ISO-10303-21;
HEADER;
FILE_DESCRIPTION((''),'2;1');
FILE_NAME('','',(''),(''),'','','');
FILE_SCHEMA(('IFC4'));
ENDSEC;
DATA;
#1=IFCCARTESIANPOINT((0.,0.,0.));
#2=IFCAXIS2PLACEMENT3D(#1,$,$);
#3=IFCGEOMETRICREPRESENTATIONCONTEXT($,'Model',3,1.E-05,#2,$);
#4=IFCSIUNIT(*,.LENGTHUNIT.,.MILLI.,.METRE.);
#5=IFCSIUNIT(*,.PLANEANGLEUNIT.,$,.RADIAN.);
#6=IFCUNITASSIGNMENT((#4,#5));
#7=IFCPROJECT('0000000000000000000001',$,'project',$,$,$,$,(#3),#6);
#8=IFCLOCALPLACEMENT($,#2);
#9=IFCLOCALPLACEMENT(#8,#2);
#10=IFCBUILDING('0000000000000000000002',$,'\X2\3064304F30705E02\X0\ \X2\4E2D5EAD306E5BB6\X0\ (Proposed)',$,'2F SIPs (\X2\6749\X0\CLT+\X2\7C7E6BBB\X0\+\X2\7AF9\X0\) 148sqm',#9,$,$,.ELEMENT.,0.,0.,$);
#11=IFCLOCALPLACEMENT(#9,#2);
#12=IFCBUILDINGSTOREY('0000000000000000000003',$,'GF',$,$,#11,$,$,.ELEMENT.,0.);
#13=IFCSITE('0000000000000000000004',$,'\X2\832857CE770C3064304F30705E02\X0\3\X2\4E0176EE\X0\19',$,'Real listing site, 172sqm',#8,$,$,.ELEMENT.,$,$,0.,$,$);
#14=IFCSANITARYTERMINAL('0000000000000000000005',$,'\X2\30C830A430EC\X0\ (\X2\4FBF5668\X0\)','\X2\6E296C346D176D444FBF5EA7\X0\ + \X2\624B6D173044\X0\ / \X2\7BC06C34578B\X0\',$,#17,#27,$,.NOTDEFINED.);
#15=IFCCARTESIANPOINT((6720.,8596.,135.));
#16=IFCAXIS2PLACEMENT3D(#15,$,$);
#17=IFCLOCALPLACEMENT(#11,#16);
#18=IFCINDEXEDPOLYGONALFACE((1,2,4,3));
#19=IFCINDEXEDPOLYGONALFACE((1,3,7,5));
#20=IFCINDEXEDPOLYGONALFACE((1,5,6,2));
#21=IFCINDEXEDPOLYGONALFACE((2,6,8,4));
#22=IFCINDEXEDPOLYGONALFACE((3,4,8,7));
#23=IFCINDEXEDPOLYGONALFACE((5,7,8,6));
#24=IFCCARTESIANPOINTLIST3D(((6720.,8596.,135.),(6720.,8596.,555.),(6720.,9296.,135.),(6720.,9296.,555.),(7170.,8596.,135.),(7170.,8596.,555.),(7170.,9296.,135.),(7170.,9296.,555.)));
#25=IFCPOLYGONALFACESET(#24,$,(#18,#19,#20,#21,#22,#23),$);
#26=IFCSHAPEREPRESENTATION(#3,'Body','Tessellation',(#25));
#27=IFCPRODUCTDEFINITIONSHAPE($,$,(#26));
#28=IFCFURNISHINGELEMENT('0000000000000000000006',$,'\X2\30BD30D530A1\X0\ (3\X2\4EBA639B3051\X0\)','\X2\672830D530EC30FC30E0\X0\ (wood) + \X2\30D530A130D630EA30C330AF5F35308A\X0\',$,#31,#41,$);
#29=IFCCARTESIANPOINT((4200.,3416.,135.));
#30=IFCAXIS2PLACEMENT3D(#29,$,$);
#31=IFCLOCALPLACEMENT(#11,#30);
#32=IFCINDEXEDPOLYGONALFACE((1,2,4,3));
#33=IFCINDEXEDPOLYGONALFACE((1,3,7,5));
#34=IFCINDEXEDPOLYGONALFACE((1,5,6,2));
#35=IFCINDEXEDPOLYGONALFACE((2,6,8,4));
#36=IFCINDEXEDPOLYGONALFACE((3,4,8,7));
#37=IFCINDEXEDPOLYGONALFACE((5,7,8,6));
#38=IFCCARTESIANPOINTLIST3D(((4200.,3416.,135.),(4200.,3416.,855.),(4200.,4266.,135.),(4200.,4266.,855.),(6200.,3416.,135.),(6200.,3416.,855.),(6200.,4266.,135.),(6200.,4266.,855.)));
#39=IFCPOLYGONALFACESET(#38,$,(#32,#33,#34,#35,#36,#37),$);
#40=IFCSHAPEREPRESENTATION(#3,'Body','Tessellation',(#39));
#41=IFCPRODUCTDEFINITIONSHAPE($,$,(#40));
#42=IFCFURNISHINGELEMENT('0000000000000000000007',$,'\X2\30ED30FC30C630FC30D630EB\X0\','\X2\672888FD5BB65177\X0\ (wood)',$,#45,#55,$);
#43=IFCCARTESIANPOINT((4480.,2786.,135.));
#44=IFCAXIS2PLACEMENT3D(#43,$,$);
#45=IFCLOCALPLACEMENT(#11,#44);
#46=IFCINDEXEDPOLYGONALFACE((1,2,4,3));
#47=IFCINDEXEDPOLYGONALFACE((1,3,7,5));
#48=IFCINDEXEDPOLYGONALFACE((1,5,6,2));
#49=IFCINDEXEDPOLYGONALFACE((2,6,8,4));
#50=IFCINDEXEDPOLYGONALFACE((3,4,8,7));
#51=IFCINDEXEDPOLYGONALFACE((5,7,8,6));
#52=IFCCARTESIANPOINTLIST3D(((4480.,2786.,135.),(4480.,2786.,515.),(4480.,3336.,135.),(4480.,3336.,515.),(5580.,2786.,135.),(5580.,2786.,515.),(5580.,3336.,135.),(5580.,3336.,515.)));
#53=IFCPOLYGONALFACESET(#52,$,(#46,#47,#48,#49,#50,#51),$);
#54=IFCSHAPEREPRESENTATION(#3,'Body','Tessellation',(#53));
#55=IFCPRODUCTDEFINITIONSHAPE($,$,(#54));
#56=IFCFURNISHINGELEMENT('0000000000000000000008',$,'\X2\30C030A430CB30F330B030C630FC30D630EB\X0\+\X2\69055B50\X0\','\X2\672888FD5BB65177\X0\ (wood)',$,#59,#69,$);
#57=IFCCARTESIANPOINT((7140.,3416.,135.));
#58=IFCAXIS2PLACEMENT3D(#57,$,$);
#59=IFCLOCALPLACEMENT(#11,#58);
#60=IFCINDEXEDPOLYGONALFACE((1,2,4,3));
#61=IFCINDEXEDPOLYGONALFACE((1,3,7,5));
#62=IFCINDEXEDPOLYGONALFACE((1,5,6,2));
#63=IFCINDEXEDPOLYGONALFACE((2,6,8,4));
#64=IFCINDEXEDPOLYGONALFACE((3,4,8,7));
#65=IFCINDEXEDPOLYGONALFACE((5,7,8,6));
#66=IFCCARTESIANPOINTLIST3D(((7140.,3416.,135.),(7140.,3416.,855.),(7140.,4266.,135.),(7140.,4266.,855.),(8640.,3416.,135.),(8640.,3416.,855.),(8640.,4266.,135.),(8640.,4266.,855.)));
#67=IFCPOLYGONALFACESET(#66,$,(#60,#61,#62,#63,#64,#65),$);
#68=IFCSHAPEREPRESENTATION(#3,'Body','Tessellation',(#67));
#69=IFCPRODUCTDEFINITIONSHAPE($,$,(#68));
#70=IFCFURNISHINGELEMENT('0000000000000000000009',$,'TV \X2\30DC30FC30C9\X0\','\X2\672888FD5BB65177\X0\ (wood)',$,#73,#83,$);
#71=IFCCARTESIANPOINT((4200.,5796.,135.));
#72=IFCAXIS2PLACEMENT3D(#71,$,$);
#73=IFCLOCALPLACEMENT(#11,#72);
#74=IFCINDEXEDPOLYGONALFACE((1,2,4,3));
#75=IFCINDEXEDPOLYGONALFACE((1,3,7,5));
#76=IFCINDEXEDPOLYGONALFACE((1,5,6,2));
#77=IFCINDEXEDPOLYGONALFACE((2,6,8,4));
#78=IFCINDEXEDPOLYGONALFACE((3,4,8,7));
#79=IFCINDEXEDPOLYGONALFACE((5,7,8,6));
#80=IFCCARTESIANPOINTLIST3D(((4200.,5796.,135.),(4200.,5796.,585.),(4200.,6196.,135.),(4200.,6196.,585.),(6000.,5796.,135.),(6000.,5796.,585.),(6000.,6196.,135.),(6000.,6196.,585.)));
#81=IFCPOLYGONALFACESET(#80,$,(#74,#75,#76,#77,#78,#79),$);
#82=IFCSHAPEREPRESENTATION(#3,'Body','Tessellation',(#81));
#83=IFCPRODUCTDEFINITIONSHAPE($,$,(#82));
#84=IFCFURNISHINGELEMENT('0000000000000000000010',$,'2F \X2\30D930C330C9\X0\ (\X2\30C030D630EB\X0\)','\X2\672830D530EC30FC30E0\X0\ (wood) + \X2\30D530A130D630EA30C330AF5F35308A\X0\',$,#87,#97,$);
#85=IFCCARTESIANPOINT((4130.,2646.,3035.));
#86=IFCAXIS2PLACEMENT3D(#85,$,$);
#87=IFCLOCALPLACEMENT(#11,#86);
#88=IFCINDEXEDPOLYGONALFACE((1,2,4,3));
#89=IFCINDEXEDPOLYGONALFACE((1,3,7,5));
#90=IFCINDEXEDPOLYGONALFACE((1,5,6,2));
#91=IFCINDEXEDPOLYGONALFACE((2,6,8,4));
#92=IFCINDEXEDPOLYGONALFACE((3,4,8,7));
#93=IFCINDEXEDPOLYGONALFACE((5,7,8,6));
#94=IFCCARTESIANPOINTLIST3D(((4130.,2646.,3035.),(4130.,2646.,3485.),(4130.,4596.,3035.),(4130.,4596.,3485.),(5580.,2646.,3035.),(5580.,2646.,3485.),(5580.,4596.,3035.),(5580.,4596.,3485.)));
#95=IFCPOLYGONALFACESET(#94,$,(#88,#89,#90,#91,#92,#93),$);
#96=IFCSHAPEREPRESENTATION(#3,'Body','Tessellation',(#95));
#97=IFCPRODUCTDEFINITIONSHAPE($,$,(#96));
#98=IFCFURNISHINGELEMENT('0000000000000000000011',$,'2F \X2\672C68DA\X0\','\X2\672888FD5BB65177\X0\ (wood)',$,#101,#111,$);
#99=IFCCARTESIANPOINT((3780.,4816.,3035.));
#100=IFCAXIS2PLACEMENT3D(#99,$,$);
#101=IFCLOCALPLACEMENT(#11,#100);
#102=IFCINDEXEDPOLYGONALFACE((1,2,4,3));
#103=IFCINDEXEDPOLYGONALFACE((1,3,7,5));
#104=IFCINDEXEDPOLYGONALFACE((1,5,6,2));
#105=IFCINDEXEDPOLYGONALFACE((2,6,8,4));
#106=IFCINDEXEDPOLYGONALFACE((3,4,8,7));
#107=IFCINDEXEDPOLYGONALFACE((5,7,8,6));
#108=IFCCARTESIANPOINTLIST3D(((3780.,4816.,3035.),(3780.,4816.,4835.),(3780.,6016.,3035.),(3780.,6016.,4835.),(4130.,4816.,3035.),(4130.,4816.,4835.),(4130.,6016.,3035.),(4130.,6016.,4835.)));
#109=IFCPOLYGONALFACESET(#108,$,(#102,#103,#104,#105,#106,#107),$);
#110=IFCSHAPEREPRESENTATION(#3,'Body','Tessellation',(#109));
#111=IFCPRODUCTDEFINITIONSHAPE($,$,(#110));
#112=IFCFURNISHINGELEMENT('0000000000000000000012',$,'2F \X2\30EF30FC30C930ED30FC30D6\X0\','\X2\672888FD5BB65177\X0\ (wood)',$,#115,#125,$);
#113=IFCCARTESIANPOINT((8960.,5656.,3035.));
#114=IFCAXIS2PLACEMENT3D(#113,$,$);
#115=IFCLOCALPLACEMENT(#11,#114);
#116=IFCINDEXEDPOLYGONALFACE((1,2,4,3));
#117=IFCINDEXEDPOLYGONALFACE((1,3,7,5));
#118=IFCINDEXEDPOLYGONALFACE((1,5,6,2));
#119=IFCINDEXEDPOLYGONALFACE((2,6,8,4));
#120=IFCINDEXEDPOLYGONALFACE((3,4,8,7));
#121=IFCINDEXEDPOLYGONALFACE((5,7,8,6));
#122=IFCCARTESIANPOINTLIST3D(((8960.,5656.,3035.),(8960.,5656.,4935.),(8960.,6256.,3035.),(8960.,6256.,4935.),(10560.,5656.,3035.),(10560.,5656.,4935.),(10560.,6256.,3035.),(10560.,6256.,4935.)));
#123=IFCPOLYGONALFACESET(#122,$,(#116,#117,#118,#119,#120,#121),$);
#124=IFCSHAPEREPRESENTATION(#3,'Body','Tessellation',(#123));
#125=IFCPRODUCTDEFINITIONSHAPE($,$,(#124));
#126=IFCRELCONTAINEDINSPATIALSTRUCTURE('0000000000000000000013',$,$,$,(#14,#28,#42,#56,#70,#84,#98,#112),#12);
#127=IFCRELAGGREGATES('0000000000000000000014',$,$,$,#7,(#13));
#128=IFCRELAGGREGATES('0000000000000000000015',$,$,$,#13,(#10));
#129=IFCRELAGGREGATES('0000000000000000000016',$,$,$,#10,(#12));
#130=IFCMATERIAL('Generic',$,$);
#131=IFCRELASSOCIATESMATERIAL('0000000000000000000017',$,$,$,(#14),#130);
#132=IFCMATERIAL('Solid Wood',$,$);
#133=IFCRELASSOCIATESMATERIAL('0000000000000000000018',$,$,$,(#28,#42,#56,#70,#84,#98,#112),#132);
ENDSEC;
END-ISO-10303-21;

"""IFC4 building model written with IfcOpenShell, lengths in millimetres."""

from ifc_helpers import new_model, si_unit, frame, frame_2d, origin, place, context, project, spatial, rectangle, extrude, material, element, save


model = new_model("IFC4")

# Units and contexts
model_context = context("Model", 3, precision=1e-05, world=origin())
ifc_project = project(units=[si_unit("LENGTHUNIT", "METRE", prefix="MILLI"), si_unit("PLANEANGLEUNIT", "RADIAN")], contexts=[model_context])

# Site, building, storey
site_placement = place(None, origin())
site = spatial("IfcSite", under=ifc_project, at=site_placement, Name="茨城県つくば市3丁目19", ObjectType="Real listing site, 172sqm", CompositionType="ELEMENT", RefElevation=0.0)
building_placement = place(site_placement, origin())
building = spatial("IfcBuilding", under=site, at=building_placement, Name="つくば市 中庭の家 (Proposed)", ObjectType="2F SIPs (杉CLT+籾殻+竹) 148sqm", CompositionType="ELEMENT", ElevationOfRefHeight=0.0, ElevationOfTerrain=0.0)
storey_placement = place(building_placement, origin())
storey = spatial("IfcBuildingStorey", under=building, at=storey_placement, Name="GF", CompositionType="ELEMENT", Elevation=0.0)

# Shared definitions
ifc_material_1 = material(Name="Solid Wood")

# Shared definitions
ifc_material_2 = material(Name="Generic")

# Sanitary terminal
sanitary_terminal_1_placement = place(storey_placement, frame((6720.0, 8596.0, 135.0)))
element("IfcSanitaryTerminal", 1, at=sanitary_terminal_1_placement, inside=storey, material=ifc_material_2, Name="トイレ (便器)", Description="温水洗浄便座 + 手洗い / 節水型", PredefinedType="NOTDEFINED", context=model_context, shape_type="SweptSolid", body=[
    extrude(rectangle(XDim=450.0, YDim=700.0, at=frame_2d((225.0, 350.0))), frame((6720.0, 8596.0, 135.0)), (0.0, 0.0, 1.0), 420.0),
])

# Furnishing elements
furnishing_1_placement = place(storey_placement, frame((4200.0, 3416.0, 135.0)))
element("IfcFurnishingElement", 2, at=furnishing_1_placement, inside=storey, material=ifc_material_1, Name="ソファ (3人掛け)", Description="木フレーム (wood) + ファブリック張り", context=model_context, shape_type="SweptSolid", body=[
    extrude(rectangle(XDim=2000.0, YDim=850.0, at=frame_2d((1000.0, 425.0))), frame((4200.0, 3416.0, 135.0)), (0.0, 0.0, 1.0), 720.0),
])
furnishing_2_placement = place(storey_placement, frame((4480.0, 2786.0, 135.0)))
element("IfcFurnishingElement", 3, at=furnishing_2_placement, inside=storey, material=ifc_material_1, Name="ローテーブル", Description="木製家具 (wood)", context=model_context, shape_type="SweptSolid", body=[
    extrude(rectangle(XDim=1100.0, YDim=550.0, at=frame_2d((550.0, 275.0))), frame((4480.0, 2786.0, 135.0)), (0.0, 0.0, 1.0), 380.0),
])
furnishing_3_placement = place(storey_placement, frame((7140.0, 3416.0, 135.0)))
element("IfcFurnishingElement", 4, at=furnishing_3_placement, inside=storey, material=ifc_material_1, Name="ダイニングテーブル+椅子", Description="木製家具 (wood)", context=model_context, shape_type="SweptSolid", body=[
    extrude(rectangle(XDim=1500.0, YDim=850.0, at=frame_2d((750.0, 425.0))), frame((7140.0, 3416.0, 135.0)), (0.0, 0.0, 1.0), 720.0),
])
furnishing_4_placement = place(storey_placement, frame((4200.0, 5796.0, 135.0)))
element("IfcFurnishingElement", 5, at=furnishing_4_placement, inside=storey, material=ifc_material_1, Name="TV ボード", Description="木製家具 (wood)", context=model_context, shape_type="SweptSolid", body=[
    extrude(rectangle(XDim=1800.0, YDim=400.0, at=frame_2d((900.0, 200.0))), frame((4200.0, 5796.0, 135.0)), (0.0, 0.0, 1.0), 450.0),
])
furnishing_5_placement = place(storey_placement, frame((4130.0, 2646.0, 3035.0)))
element("IfcFurnishingElement", 6, at=furnishing_5_placement, inside=storey, material=ifc_material_1, Name="2F ベッド (ダブル)", Description="木フレーム (wood) + ファブリック張り", context=model_context, shape_type="SweptSolid", body=[
    extrude(rectangle(XDim=1450.0, YDim=1950.0, at=frame_2d((725.0, 975.0))), frame((4130.0, 2646.0, 3035.0)), (0.0, 0.0, 1.0), 450.0),
])
furnishing_6_placement = place(storey_placement, frame((3780.0, 4816.0, 3035.0)))
element("IfcFurnishingElement", 7, at=furnishing_6_placement, inside=storey, material=ifc_material_1, Name="2F 本棚", Description="木製家具 (wood)", context=model_context, shape_type="SweptSolid", body=[
    extrude(rectangle(XDim=350.0, YDim=1200.0, at=frame_2d((175.0, 600.0))), frame((3780.0, 4816.0, 3035.0)), (0.0, 0.0, 1.0), 1800.0),
])
furnishing_7_placement = place(storey_placement, frame((8960.0, 5656.0, 3035.0)))
element("IfcFurnishingElement", 8, at=furnishing_7_placement, inside=storey, material=ifc_material_1, Name="2F ワードローブ", Description="木製家具 (wood)", context=model_context, shape_type="SweptSolid", body=[
    extrude(rectangle(XDim=1600.0, YDim=600.0, at=frame_2d((800.0, 300.0))), frame((8960.0, 5656.0, 3035.0)), (0.0, 0.0, 1.0), 1900.0),
])

save(model, "model.ifc")
